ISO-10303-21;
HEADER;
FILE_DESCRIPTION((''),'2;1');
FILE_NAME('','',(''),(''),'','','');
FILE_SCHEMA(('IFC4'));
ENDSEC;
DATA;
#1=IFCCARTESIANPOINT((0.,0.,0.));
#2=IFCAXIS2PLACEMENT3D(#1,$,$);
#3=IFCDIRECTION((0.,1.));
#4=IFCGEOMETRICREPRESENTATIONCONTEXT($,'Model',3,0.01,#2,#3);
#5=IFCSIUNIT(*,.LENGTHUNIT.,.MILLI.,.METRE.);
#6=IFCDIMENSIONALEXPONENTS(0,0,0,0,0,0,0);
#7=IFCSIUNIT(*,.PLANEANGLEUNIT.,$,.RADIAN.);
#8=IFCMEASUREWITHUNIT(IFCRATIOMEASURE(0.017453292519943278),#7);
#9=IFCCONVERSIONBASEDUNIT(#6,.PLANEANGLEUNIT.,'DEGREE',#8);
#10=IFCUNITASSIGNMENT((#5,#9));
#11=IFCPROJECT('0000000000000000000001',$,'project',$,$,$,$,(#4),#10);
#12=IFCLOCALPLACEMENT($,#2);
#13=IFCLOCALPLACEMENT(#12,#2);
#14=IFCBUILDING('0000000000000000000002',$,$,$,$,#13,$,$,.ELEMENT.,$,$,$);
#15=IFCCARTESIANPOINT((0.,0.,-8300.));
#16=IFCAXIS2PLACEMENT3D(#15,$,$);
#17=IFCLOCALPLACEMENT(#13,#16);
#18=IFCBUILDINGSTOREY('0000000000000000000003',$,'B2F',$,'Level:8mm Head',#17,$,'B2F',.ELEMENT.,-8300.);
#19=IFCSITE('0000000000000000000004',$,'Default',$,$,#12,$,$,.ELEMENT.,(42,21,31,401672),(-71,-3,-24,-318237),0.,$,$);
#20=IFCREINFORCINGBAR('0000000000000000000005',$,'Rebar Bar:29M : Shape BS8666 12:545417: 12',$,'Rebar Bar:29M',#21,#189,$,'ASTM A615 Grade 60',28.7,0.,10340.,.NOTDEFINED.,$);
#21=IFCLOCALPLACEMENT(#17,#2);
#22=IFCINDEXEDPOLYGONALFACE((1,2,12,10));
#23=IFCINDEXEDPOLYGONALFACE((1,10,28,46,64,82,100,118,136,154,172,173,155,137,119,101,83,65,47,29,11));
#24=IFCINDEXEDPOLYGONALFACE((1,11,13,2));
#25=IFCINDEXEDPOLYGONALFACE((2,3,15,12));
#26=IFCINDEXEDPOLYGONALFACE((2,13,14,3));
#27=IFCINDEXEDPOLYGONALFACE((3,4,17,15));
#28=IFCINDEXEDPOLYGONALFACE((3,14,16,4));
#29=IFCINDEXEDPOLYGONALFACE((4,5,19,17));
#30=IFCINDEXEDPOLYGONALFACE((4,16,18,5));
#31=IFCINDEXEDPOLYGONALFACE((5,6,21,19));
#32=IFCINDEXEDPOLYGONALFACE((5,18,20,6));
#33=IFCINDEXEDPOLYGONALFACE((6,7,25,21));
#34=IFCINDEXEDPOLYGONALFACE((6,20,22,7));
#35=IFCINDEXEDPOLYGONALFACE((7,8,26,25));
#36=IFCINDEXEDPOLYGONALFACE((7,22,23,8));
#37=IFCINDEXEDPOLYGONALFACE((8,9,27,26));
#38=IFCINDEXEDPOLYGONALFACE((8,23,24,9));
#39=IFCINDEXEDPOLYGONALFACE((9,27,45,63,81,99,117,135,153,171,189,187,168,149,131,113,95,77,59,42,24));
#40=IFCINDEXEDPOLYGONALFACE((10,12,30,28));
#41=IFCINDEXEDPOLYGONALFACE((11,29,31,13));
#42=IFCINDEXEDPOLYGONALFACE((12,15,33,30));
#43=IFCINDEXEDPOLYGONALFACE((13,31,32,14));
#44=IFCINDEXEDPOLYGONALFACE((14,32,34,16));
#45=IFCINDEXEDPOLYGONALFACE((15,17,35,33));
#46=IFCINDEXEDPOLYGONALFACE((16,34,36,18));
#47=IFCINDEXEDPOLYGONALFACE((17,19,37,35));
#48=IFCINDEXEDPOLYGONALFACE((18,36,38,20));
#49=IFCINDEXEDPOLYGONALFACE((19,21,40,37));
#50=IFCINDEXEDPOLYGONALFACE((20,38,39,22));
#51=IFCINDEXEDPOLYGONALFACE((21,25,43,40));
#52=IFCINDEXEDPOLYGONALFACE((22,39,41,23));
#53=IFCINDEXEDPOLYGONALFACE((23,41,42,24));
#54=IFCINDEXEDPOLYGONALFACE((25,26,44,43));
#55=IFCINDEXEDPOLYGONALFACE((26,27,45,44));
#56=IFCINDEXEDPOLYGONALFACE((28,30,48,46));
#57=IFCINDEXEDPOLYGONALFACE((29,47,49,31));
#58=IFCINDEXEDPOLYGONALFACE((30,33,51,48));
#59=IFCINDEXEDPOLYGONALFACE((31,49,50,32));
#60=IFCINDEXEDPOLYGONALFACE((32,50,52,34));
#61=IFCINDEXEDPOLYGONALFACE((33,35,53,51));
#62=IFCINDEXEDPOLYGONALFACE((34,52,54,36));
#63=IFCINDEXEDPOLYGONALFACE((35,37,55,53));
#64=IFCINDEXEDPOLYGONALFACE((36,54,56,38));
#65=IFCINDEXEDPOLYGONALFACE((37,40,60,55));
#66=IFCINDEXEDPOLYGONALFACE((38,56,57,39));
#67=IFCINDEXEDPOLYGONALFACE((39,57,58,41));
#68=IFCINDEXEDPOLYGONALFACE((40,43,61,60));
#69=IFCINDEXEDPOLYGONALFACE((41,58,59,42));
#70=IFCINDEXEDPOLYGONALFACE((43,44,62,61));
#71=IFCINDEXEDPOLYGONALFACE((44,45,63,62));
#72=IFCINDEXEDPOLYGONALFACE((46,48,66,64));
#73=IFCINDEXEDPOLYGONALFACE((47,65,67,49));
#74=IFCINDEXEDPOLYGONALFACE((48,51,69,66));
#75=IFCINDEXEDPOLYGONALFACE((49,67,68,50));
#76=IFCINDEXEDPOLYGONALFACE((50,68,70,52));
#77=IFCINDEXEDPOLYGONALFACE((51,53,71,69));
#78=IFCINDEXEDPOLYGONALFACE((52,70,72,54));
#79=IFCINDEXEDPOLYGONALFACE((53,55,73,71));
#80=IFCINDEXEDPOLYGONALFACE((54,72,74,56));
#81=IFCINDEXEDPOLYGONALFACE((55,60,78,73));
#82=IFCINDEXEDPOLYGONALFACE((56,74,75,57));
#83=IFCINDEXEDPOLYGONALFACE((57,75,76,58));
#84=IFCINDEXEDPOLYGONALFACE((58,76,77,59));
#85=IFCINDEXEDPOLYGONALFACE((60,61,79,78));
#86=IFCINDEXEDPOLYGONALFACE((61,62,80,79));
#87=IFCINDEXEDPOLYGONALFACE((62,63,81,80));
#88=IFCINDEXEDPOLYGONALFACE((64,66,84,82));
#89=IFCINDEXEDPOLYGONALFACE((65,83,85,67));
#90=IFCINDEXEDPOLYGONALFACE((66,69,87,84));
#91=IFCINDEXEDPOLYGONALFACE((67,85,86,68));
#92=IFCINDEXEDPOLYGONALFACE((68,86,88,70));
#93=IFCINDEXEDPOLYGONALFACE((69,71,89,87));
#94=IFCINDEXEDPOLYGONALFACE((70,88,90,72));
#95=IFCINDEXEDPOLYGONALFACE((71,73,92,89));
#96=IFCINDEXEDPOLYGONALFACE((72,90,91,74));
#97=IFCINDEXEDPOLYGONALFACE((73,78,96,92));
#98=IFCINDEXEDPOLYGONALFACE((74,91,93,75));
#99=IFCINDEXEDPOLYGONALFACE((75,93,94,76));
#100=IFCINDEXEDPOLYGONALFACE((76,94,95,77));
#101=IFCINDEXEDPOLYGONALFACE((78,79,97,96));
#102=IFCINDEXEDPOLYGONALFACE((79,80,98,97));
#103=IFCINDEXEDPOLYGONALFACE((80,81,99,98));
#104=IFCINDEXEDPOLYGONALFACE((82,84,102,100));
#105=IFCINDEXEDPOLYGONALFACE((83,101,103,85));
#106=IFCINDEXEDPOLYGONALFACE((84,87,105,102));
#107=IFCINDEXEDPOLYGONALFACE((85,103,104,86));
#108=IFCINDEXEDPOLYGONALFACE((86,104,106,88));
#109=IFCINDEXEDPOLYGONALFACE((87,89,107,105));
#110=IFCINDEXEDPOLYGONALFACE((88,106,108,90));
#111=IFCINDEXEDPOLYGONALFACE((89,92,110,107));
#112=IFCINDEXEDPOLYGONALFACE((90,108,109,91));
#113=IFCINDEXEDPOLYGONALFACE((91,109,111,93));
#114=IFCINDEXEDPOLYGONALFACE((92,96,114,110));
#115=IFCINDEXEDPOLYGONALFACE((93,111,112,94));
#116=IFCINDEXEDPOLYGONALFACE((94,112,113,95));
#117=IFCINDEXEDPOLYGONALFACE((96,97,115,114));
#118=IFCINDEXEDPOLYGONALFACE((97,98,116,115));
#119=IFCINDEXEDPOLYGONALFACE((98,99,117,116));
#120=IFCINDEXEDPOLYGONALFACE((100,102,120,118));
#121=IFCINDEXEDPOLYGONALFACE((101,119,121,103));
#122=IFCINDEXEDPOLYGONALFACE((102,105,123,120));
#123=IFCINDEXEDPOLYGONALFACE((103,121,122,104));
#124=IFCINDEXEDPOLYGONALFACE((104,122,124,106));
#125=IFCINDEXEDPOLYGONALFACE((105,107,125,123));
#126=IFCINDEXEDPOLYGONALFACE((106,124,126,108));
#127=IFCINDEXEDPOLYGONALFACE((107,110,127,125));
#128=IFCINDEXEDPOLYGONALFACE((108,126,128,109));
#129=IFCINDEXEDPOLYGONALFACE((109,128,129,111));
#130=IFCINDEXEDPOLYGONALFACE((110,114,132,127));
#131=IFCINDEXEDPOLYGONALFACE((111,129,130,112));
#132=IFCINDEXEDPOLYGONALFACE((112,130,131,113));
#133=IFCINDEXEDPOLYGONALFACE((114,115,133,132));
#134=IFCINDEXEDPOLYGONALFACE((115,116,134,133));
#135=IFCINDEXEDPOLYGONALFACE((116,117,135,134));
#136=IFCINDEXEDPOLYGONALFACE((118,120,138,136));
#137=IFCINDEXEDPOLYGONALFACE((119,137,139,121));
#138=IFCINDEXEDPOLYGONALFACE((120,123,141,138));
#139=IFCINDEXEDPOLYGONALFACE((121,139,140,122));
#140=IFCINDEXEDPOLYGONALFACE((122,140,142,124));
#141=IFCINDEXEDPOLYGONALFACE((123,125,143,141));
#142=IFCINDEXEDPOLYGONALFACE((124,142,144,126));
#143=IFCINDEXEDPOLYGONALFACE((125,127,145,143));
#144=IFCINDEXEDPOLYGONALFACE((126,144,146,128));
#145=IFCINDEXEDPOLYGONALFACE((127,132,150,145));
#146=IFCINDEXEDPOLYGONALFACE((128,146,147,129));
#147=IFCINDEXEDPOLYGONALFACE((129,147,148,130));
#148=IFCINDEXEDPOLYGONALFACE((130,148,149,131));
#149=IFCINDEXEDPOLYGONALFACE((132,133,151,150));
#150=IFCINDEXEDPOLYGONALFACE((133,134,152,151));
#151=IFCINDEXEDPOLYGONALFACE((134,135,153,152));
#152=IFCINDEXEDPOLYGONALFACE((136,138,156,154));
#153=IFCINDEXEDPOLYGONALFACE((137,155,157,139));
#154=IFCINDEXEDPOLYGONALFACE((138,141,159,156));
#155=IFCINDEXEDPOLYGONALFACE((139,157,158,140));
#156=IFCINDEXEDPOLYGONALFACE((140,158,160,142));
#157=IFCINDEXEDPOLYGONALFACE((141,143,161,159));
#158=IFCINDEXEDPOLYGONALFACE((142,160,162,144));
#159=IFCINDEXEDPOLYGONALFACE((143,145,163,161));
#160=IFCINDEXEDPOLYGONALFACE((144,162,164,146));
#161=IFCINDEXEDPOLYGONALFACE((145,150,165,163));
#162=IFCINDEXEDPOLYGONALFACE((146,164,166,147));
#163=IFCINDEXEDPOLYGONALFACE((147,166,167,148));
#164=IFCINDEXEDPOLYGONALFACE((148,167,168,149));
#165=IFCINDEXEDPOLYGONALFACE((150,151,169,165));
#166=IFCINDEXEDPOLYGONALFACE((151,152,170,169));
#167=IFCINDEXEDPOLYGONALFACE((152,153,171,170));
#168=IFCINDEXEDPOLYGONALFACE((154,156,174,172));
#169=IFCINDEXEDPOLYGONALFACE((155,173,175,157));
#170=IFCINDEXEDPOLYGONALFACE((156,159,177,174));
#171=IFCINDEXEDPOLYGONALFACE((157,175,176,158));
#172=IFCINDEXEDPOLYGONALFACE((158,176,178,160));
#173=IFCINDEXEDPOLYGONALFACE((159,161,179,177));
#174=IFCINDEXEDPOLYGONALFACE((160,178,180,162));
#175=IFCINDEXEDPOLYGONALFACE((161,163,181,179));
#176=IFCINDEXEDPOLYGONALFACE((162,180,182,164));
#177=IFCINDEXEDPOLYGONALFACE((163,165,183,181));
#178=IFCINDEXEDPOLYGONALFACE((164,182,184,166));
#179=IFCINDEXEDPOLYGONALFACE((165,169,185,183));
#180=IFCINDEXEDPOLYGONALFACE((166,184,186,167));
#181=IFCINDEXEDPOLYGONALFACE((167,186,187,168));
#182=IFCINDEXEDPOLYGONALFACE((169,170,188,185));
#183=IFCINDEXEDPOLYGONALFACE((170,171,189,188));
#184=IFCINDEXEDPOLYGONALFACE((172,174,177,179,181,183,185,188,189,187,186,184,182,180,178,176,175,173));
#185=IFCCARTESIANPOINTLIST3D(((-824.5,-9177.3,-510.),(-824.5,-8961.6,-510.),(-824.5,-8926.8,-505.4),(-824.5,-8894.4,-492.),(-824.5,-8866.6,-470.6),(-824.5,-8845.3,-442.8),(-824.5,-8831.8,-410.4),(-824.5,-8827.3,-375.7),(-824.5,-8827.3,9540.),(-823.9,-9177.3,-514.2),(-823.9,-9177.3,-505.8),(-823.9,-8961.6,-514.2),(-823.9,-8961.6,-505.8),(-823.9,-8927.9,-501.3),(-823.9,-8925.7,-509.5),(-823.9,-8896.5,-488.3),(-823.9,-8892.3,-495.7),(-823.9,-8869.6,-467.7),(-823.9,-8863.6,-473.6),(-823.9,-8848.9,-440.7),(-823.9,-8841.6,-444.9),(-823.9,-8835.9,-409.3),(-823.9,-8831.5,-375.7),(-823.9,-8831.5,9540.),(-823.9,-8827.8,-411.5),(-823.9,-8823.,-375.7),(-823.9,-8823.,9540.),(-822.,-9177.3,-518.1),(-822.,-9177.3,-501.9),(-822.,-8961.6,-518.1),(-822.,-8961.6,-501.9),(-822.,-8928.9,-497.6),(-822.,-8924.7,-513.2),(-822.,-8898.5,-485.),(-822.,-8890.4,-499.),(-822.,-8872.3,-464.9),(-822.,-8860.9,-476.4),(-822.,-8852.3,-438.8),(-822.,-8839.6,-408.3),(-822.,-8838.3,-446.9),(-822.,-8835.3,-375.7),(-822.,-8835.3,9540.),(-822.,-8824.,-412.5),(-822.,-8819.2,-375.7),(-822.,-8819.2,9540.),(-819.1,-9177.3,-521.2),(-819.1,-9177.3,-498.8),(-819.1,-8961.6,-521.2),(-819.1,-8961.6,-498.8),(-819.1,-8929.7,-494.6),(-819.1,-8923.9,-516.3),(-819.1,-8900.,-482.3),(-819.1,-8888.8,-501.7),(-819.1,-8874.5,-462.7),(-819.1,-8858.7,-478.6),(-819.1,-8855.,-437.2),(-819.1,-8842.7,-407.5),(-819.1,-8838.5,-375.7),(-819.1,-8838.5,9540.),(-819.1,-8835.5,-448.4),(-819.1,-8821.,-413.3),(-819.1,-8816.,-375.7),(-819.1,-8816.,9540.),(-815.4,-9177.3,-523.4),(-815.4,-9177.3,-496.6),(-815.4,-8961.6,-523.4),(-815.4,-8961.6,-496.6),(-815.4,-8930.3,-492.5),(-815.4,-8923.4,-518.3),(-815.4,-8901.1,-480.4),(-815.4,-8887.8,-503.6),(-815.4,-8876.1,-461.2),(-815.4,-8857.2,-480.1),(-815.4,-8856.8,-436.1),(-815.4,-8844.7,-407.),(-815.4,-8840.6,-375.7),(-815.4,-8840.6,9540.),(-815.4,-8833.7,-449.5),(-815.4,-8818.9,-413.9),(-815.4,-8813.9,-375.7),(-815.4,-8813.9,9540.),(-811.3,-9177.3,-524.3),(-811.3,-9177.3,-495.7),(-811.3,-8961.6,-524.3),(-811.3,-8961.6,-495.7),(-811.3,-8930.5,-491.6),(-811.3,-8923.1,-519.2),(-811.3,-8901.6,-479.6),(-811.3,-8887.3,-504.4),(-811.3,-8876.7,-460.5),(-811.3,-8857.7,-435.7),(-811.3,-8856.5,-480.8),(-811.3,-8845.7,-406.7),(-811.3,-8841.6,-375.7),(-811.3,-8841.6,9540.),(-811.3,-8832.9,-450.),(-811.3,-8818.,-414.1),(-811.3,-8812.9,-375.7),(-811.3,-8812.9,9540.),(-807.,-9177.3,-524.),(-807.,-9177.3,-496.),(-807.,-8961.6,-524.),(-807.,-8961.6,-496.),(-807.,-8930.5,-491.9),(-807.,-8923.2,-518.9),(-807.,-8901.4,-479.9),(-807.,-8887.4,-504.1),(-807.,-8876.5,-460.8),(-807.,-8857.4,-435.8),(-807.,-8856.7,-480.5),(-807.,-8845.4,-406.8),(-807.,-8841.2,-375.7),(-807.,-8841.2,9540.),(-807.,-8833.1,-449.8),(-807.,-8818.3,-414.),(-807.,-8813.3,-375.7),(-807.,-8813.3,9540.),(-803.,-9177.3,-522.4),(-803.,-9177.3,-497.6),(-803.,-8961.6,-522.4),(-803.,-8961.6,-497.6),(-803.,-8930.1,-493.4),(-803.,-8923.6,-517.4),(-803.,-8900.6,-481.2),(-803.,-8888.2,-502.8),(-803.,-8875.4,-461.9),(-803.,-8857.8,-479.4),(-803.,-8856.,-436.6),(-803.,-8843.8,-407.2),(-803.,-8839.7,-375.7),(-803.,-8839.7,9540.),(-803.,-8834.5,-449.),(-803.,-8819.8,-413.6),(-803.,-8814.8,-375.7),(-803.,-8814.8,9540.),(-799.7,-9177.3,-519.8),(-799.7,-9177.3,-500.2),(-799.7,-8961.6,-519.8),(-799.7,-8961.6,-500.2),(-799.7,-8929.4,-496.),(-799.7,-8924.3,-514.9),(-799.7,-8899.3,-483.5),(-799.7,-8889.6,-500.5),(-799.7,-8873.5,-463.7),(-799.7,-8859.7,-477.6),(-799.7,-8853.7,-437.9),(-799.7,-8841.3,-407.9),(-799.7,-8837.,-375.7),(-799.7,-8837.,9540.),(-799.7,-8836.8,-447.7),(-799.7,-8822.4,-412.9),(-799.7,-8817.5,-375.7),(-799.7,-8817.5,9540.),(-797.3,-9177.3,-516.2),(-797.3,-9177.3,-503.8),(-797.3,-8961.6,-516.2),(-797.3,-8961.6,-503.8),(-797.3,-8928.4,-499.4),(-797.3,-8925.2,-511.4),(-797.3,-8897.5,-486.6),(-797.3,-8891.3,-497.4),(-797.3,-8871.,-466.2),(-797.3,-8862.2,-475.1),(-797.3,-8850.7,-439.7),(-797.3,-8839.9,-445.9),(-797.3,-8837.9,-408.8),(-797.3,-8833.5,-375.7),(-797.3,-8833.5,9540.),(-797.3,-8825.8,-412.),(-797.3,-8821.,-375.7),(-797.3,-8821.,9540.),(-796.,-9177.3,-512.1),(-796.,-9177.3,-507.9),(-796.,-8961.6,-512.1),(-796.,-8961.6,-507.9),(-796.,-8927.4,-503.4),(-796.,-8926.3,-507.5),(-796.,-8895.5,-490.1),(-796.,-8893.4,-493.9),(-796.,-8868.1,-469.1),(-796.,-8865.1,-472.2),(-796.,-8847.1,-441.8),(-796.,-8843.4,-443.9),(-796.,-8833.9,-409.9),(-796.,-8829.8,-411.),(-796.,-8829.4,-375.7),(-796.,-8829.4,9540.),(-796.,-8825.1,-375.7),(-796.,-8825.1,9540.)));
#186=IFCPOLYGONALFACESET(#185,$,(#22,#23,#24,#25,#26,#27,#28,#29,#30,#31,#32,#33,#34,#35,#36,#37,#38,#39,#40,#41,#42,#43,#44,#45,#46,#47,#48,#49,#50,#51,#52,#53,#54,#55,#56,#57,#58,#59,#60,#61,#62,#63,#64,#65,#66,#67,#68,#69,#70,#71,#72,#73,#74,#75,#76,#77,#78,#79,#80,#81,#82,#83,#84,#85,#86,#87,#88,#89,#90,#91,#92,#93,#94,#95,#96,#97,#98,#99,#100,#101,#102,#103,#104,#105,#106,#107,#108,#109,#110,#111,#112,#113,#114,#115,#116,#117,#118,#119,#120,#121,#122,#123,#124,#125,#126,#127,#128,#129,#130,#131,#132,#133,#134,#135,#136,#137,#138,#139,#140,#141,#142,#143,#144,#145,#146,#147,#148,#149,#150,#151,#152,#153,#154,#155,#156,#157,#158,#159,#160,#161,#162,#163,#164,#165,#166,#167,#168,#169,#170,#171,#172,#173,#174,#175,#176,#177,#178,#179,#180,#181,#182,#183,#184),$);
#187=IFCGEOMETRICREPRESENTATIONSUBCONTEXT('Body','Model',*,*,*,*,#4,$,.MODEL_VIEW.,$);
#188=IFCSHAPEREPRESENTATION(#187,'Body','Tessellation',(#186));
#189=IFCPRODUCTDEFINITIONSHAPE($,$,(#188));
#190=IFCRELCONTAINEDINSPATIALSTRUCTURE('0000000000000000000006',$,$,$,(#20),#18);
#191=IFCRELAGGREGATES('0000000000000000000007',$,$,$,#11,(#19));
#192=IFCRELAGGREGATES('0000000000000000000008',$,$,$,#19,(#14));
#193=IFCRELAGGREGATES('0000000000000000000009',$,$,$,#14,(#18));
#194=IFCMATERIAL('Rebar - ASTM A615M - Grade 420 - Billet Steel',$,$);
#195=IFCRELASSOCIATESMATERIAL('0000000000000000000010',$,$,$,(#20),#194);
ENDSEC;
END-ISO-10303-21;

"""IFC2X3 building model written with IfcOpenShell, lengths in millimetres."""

from ifc_helpers import new_model, entity, si_unit, converted_unit, direction, frame, origin, place, context, subcontext, project, spatial, material, element, save


model = new_model("IFC2X3")

# Units and contexts
model_context = context("Model", 3, precision=0.01, world=origin(), true_north=direction((0.0, 1.0)))
body_context = subcontext(model_context, "Body", "Model", "MODEL_VIEW")
ifc_project = project(units=[si_unit("LENGTHUNIT", "METRE", prefix="MILLI"), converted_unit("PLANEANGLEUNIT", "DEGREE", entity("IfcRatioMeasure", 0.017453292519943278), si_unit("PLANEANGLEUNIT", "RADIAN"), dimensions=[0, 0, 0, 0, 0, 0, 0])], contexts=[model_context])

# Site, building, storey
site_placement = place(None, origin())
site = spatial("IfcSite", under=ifc_project, at=site_placement, Name="Default", CompositionType="ELEMENT", RefLatitude=(42, 21, 31, 401672), RefLongitude=(-71, -3, -24, -318237), RefElevation=0.0)
building_placement = place(site_placement, origin())
building = spatial("IfcBuilding", under=site, at=building_placement, CompositionType="ELEMENT")
storey_placement = place(building_placement, frame((0.0, 0.0, -8300.0)))
storey = spatial("IfcBuildingStorey", under=building, at=storey_placement, Name="B2F", ObjectType="Level:8mm Head", LongName="B2F", CompositionType="ELEMENT", Elevation=-8300.0)

# Reinforcing bar
ifc_material_1 = material(Name="Rebar - ASTM A615M - Grade 420 - Billet Steel")
reinforcing_bar_1_placement = place(storey_placement, origin())
element("IfcReinforcingBar", 1, at=reinforcing_bar_1_placement, inside=storey, material=ifc_material_1, Name="Rebar Bar:29M : Shape BS8666 12:545417: 12", SteelGrade="ASTM A615 Grade 60", ObjectType="Rebar Bar:29M", BarLength=10340.0, BarRole="NOTDEFINED", CrossSectionArea=0.0, NominalDiameter=28.7, context=body_context, shape_type="AdvancedSweptSolid", body=[
    entity("IfcSweptDiskSolid", entity("IfcCompositeCurve", [entity("IfcCompositeCurveSegment", "CONTINUOUS", True, entity("IfcPolyline", [entity("IfcCartesianPoint", [-810.2, -8827.3, 9540.0]), entity("IfcCartesianPoint", [-810.2, -8827.3, -375.7])])), entity("IfcCompositeCurveSegment", "CONTINUOUS", True, entity("IfcTrimmedCurve", entity("IfcCircle", entity("IfcAxis2Placement3D", entity("IfcCartesianPoint", [-810.2, -8961.6, -375.7]), entity("IfcDirection", [-1.0, 0.0, 0.0]), entity("IfcDirection", [0.0, 0.0, -1.0])), 134.3), [entity("IfcParameterValue", 270.0)], [entity("IfcParameterValue", 360.0)], True, "PARAMETER")), entity("IfcCompositeCurveSegment", "CONTINUOUS", True, entity("IfcPolyline", [entity("IfcCartesianPoint", [-810.2, -8961.6, -510.0]), entity("IfcCartesianPoint", [-810.2, -9177.3, -510.0])]))], False), 14.3, None, 0.0, 92.0),
])

save(model, "model.ifc")
